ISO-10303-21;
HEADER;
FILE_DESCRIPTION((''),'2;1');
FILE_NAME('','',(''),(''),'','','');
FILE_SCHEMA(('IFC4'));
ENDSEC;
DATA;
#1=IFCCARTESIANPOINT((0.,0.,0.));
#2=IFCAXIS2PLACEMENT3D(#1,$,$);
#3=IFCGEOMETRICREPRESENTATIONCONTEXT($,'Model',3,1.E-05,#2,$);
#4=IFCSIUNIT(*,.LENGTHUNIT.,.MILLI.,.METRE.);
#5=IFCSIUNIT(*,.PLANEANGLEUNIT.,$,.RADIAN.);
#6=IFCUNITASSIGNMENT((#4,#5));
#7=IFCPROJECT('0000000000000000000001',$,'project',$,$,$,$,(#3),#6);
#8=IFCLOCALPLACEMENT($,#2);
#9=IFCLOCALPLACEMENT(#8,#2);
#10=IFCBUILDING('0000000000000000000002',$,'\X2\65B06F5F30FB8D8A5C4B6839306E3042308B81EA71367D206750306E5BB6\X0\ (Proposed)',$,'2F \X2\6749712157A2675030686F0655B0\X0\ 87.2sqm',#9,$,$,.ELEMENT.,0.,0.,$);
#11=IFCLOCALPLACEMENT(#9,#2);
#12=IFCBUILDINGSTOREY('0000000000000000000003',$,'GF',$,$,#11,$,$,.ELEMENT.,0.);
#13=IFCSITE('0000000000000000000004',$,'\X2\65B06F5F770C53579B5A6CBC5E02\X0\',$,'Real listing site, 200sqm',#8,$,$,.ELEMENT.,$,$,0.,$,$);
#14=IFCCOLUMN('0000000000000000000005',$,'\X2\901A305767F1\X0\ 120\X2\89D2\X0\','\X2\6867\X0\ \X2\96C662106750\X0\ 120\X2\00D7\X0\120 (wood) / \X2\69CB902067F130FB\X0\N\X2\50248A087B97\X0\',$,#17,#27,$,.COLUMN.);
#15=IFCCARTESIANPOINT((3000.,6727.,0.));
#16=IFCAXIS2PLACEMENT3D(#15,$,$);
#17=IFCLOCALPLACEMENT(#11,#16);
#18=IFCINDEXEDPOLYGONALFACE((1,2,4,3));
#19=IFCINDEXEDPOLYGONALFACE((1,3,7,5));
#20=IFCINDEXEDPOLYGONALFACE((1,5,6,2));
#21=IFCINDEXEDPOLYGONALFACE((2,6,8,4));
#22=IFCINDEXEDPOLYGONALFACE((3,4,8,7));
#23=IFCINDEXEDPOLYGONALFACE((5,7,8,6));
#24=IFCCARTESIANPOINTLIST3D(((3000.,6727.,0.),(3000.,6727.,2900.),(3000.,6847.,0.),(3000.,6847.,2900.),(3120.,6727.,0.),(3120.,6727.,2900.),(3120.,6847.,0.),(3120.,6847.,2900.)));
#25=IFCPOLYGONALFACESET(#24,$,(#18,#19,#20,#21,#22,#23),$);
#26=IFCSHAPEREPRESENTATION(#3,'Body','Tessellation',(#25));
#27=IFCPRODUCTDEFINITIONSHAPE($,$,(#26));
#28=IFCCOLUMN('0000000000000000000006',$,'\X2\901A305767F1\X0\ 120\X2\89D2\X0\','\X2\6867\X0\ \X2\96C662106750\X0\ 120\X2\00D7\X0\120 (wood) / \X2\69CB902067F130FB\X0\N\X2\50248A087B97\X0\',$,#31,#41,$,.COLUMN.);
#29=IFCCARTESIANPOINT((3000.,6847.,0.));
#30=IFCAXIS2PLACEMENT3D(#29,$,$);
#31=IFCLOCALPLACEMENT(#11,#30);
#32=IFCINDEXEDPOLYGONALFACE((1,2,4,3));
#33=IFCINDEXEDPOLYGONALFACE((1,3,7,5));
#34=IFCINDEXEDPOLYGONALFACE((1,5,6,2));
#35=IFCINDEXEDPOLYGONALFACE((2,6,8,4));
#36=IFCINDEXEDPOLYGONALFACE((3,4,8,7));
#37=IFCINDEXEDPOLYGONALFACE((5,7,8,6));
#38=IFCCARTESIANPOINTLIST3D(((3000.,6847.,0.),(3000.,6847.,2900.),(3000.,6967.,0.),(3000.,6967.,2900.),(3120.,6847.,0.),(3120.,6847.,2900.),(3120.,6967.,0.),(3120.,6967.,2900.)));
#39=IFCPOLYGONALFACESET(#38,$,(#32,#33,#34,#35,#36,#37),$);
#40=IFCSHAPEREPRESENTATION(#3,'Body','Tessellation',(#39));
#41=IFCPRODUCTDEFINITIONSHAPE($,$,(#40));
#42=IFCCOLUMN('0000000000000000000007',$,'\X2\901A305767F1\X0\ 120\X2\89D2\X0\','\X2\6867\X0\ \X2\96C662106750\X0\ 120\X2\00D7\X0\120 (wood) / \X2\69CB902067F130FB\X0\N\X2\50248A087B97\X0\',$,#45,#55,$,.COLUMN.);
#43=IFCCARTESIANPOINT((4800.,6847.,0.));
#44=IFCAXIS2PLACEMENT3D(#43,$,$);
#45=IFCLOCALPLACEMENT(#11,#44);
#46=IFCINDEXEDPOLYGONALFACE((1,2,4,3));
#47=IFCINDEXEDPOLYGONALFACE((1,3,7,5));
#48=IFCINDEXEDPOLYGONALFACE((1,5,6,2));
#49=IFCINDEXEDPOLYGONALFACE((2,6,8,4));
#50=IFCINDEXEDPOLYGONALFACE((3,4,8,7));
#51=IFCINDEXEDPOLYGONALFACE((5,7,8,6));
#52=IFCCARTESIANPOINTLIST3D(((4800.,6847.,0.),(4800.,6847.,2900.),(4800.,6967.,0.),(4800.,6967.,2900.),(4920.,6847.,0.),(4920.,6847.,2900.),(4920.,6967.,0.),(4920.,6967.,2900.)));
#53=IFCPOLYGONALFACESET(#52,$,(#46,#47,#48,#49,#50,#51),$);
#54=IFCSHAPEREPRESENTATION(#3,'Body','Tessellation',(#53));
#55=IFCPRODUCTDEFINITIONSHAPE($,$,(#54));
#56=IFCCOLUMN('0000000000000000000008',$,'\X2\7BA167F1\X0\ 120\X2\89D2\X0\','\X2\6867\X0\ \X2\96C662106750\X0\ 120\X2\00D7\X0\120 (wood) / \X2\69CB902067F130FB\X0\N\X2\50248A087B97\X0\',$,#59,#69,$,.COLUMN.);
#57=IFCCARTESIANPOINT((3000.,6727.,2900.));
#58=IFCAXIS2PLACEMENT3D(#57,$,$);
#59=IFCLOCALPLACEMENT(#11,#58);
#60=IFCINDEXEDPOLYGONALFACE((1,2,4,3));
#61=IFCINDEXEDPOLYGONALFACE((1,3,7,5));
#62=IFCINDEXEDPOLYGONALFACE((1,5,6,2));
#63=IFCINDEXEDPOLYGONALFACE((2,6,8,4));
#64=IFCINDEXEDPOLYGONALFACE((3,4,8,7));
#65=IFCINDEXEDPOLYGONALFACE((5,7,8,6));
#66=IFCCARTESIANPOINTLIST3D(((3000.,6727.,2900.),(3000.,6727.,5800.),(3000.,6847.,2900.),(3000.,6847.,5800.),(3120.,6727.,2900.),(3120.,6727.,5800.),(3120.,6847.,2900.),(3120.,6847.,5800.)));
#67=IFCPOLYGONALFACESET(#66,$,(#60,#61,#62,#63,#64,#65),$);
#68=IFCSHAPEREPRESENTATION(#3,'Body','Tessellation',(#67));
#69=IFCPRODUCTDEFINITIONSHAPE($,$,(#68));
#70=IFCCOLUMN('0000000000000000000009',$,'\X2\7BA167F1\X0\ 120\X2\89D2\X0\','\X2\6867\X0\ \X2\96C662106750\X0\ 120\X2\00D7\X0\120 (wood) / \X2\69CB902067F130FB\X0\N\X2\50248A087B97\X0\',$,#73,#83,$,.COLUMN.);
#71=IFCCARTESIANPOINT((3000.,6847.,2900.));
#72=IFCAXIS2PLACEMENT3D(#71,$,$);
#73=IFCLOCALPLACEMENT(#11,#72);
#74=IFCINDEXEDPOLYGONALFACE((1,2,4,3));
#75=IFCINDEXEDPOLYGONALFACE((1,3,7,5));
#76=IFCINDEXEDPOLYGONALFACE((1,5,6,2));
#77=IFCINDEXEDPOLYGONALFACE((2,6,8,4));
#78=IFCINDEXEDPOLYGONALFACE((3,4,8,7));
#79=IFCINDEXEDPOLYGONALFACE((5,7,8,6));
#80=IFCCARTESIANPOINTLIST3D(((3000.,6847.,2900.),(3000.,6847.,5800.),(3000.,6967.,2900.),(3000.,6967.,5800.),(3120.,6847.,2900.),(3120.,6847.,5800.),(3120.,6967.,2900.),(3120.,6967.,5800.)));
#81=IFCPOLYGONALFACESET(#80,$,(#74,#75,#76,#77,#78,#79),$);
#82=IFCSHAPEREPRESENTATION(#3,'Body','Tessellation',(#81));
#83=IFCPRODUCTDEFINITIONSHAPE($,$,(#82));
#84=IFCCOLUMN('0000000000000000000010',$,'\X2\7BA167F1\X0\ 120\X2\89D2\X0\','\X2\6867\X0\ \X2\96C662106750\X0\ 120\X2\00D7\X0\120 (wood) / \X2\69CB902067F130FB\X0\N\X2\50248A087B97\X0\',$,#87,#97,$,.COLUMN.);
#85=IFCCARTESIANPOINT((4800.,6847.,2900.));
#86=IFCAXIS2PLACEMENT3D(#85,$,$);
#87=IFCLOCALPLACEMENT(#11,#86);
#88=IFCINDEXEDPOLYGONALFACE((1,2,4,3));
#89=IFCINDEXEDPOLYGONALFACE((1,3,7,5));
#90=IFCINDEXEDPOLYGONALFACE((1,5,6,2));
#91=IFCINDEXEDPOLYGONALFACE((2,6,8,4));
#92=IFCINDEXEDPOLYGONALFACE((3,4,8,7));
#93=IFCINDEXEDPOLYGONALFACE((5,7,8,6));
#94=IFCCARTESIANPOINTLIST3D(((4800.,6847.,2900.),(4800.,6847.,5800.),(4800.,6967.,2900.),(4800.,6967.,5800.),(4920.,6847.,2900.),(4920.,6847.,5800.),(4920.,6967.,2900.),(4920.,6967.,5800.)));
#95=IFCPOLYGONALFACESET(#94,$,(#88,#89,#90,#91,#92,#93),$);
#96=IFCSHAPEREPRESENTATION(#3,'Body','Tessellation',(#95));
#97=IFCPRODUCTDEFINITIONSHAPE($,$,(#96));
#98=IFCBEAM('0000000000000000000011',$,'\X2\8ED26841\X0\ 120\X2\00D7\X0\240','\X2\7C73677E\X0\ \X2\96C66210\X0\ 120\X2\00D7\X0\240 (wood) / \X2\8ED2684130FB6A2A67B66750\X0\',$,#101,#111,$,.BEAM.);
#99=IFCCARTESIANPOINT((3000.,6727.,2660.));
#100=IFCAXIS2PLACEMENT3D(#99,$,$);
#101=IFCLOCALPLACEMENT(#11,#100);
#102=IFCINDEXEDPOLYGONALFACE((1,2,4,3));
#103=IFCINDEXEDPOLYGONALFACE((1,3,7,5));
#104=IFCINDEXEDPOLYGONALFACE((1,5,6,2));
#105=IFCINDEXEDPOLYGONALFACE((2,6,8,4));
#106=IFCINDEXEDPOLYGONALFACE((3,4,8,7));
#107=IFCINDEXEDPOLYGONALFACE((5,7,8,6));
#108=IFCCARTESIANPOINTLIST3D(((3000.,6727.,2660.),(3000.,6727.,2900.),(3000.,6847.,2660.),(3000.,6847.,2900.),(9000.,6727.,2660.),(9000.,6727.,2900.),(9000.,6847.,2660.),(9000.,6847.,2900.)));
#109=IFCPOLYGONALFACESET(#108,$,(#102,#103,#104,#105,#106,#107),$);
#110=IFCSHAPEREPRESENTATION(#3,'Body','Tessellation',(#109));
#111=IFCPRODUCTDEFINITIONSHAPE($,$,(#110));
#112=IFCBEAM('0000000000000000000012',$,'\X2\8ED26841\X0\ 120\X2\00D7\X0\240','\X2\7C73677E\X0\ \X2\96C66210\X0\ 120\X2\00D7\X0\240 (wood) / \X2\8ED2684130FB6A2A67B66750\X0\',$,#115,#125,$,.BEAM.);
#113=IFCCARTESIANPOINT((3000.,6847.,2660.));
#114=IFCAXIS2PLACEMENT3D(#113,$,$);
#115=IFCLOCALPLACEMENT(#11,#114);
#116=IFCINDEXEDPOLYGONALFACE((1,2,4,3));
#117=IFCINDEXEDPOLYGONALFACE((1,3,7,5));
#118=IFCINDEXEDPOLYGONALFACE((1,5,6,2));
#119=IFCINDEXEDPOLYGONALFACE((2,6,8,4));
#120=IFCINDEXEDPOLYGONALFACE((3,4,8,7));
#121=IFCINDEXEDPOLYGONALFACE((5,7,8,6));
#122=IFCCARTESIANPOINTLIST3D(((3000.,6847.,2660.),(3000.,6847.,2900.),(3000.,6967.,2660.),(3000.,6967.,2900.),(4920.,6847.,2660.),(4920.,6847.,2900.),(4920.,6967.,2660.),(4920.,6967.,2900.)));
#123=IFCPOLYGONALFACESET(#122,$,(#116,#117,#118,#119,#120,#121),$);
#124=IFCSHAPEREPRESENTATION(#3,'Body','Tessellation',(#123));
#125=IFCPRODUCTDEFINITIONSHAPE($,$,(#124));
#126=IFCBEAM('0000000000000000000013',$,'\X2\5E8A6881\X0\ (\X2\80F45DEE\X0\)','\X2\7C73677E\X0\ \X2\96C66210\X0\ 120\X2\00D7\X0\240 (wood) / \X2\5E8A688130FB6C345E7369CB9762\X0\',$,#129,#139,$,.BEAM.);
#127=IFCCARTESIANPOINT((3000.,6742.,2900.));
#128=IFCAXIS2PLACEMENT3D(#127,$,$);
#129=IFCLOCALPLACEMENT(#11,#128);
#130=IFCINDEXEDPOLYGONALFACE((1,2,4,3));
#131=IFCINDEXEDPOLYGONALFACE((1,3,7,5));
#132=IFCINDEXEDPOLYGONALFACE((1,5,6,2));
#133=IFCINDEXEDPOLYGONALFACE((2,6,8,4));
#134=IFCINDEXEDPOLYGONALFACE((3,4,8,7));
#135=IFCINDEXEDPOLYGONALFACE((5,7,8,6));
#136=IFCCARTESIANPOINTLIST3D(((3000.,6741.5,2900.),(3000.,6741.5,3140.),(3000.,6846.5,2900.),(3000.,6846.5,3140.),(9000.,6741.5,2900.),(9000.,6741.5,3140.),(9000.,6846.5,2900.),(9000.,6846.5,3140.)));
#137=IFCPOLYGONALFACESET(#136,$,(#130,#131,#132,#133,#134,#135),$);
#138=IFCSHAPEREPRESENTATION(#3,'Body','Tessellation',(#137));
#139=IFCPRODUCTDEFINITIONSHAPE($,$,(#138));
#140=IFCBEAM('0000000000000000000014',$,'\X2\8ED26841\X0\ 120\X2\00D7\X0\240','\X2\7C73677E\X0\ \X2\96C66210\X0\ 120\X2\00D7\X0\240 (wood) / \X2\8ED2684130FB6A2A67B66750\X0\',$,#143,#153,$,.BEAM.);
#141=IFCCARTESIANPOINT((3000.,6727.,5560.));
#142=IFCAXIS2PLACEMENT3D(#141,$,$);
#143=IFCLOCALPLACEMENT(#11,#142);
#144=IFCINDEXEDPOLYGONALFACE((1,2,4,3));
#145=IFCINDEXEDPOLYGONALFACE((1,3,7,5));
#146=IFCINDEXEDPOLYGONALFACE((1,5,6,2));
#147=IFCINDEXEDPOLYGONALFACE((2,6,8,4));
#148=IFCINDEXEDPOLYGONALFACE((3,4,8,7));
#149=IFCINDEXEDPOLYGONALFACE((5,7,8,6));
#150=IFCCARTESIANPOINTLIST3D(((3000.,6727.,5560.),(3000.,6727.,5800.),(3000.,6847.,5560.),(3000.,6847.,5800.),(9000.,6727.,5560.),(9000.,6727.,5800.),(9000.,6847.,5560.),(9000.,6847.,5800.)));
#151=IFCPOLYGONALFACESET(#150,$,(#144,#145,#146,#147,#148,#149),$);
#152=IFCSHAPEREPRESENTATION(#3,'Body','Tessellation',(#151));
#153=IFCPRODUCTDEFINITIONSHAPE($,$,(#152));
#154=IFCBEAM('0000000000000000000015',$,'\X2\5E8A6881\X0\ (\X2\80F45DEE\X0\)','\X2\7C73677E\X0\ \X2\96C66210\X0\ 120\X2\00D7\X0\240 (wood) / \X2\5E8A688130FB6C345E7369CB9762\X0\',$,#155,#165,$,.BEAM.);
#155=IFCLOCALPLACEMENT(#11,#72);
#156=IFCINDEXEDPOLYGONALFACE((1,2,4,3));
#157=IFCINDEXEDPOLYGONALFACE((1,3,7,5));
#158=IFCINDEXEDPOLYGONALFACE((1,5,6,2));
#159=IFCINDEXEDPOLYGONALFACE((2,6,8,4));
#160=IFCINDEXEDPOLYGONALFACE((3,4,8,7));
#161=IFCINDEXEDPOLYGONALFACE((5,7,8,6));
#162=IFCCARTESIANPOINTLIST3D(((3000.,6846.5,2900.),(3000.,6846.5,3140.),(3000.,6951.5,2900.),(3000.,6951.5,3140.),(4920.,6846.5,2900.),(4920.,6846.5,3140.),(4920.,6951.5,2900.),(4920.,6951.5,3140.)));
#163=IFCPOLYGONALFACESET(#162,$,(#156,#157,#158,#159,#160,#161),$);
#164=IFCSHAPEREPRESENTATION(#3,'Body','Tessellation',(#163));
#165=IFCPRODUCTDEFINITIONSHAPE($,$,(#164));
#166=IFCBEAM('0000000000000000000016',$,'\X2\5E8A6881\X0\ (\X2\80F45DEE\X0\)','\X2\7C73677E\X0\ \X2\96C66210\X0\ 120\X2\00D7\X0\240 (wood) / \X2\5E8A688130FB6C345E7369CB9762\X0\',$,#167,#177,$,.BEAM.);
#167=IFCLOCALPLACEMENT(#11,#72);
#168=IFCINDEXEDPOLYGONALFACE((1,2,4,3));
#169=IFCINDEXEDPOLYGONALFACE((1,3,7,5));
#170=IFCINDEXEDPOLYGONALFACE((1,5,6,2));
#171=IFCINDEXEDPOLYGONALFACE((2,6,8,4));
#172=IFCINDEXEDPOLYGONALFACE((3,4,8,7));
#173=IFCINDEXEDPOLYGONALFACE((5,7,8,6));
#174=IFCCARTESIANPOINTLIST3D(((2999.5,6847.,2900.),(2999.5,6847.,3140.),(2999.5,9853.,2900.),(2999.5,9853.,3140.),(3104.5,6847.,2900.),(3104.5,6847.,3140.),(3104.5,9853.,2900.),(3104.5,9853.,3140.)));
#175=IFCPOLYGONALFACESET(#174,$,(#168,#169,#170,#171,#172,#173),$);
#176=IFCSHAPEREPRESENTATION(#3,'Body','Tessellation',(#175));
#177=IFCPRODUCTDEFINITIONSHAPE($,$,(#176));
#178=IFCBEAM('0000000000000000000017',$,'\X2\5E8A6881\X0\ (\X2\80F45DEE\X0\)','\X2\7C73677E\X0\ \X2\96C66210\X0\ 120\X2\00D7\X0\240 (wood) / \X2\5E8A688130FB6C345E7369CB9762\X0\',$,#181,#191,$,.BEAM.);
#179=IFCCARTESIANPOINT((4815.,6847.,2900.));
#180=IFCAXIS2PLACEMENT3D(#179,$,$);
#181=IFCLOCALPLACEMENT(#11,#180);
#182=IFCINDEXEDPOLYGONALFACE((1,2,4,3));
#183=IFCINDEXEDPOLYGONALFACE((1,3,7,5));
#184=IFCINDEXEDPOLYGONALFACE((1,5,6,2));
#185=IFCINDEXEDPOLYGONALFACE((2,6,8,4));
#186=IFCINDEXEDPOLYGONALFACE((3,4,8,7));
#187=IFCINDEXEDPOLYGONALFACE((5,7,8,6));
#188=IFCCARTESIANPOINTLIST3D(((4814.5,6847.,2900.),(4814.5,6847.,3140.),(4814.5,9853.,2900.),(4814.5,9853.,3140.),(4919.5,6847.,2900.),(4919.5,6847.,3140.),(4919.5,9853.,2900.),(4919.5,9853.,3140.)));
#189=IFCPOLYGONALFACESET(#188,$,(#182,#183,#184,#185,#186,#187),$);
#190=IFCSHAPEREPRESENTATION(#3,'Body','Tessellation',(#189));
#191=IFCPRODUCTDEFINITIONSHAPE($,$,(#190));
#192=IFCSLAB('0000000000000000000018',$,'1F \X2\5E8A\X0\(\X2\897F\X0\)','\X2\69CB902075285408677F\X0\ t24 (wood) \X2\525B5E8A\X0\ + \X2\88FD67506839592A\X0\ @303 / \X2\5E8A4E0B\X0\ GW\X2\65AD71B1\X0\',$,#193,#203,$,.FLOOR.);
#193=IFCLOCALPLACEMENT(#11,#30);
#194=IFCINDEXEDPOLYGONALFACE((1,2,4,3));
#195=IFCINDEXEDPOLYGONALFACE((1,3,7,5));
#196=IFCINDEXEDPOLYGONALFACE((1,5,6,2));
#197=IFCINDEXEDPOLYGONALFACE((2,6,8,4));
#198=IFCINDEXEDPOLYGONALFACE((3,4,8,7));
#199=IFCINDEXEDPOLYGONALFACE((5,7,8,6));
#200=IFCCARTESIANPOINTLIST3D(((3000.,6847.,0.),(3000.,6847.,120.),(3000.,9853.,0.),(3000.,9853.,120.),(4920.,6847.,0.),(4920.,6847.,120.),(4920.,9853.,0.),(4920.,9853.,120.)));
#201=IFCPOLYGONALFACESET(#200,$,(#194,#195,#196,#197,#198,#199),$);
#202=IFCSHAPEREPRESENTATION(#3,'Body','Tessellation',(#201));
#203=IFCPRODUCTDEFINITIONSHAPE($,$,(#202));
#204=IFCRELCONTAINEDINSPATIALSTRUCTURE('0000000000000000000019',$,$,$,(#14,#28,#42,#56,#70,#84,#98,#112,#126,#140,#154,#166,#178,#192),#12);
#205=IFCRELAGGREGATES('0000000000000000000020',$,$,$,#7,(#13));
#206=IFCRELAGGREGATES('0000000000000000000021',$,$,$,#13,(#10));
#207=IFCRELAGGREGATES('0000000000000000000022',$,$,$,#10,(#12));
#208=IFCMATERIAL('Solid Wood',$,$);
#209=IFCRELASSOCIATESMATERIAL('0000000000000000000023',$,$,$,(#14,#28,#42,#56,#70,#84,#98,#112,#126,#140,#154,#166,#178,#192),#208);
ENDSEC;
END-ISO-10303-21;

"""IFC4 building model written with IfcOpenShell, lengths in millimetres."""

from ifc_helpers import new_model, si_unit, frame, frame_2d, origin, place, context, project, spatial, rectangle, extrude, material, element, save


model = new_model("IFC4")

# Units and contexts
model_context = context("Model", 3, precision=1e-05, world=origin())
ifc_project = project(units=[si_unit("LENGTHUNIT", "METRE", prefix="MILLI"), si_unit("PLANEANGLEUNIT", "RADIAN")], contexts=[model_context])

# Site, building, storey
site_placement = place(None, origin())
site = spatial("IfcSite", under=ifc_project, at=site_placement, Name="新潟県南魚沼市", ObjectType="Real listing site, 200sqm", CompositionType="ELEMENT", RefElevation=0.0)
building_placement = place(site_placement, origin())
building = spatial("IfcBuilding", under=site, at=building_placement, Name="新潟・越屋根のある自然素材の家 (Proposed)", ObjectType="2F 杉無垢材と漆喰 87.2sqm", CompositionType="ELEMENT", ElevationOfRefHeight=0.0, ElevationOfTerrain=0.0)
storey_placement = place(building_placement, origin())
storey = spatial("IfcBuildingStorey", under=building, at=storey_placement, Name="GF", CompositionType="ELEMENT", Elevation=0.0)

# Columns
ifc_material_1 = material(Name="Solid Wood")
column_1_placement = place(storey_placement, frame((3000.0, 6727.0, 0.0)))
element("IfcColumn", 1, at=column_1_placement, inside=storey, material=ifc_material_1, Name="通し柱 120角", Description="桧 集成材 120×120 (wood) / 構造柱・N値計算", PredefinedType="COLUMN", context=model_context, shape_type="SweptSolid", body=[
    extrude(rectangle(XDim=120.0, YDim=120.0, at=frame_2d((60.0, 60.0))), frame((3000.0, 6727.0, 0.0)), (0.0, 0.0, 1.0), 2900.0),
])
column_2_placement = place(storey_placement, frame((3000.0, 6847.0, 0.0)))
element("IfcColumn", 2, at=column_2_placement, inside=storey, material=ifc_material_1, Name="通し柱 120角", Description="桧 集成材 120×120 (wood) / 構造柱・N値計算", PredefinedType="COLUMN", context=model_context, shape_type="SweptSolid", body=[
    extrude(rectangle(XDim=120.0, YDim=120.0, at=frame_2d((60.0, 60.0))), frame((3000.0, 6847.0, 0.0)), (0.0, 0.0, 1.0), 2900.0),
])
column_3_placement = place(storey_placement, frame((4800.0, 6847.0, 0.0)))
element("IfcColumn", 3, at=column_3_placement, inside=storey, material=ifc_material_1, Name="通し柱 120角", Description="桧 集成材 120×120 (wood) / 構造柱・N値計算", PredefinedType="COLUMN", context=model_context, shape_type="SweptSolid", body=[
    extrude(rectangle(XDim=120.0, YDim=120.0, at=frame_2d((60.0, 60.0))), frame((4800.0, 6847.0, 0.0)), (0.0, 0.0, 1.0), 2900.0),
])
column_4_placement = place(storey_placement, frame((3000.0, 6727.0, 2900.0)))
element("IfcColumn", 4, at=column_4_placement, inside=storey, material=ifc_material_1, Name="管柱 120角", Description="桧 集成材 120×120 (wood) / 構造柱・N値計算", PredefinedType="COLUMN", context=model_context, shape_type="SweptSolid", body=[
    extrude(rectangle(XDim=120.0, YDim=120.0, at=frame_2d((60.0, 60.0))), frame((3000.0, 6727.0, 2900.0)), (0.0, 0.0, 1.0), 2900.0),
])
column_5_placement = place(storey_placement, frame((3000.0, 6847.0, 2900.0)))
element("IfcColumn", 5, at=column_5_placement, inside=storey, material=ifc_material_1, Name="管柱 120角", Description="桧 集成材 120×120 (wood) / 構造柱・N値計算", PredefinedType="COLUMN", context=model_context, shape_type="SweptSolid", body=[
    extrude(rectangle(XDim=120.0, YDim=120.0, at=frame_2d((60.0, 60.0))), frame((3000.0, 6847.0, 2900.0)), (0.0, 0.0, 1.0), 2900.0),
])
column_6_placement = place(storey_placement, frame((4800.0, 6847.0, 2900.0)))
element("IfcColumn", 6, at=column_6_placement, inside=storey, material=ifc_material_1, Name="管柱 120角", Description="桧 集成材 120×120 (wood) / 構造柱・N値計算", PredefinedType="COLUMN", context=model_context, shape_type="SweptSolid", body=[
    extrude(rectangle(XDim=120.0, YDim=120.0, at=frame_2d((60.0, 60.0))), frame((4800.0, 6847.0, 2900.0)), (0.0, 0.0, 1.0), 2900.0),
])

# Beams
beam_1_placement = place(storey_placement, frame((3000.0, 6727.0, 2660.0)))
element("IfcBeam", 7, at=beam_1_placement, inside=storey, material=ifc_material_1, Name="軒桁 120×240", Description="米松 集成 120×240 (wood) / 軒桁・横架材", PredefinedType="BEAM", context=model_context, shape_type="SweptSolid", body=[
    extrude(rectangle(XDim=6000.0, YDim=120.0, at=frame_2d((3000.0, 60.0))), frame((3000.0, 6727.0, 2660.0)), (0.0, 0.0, 1.0), 240.0),
])
beam_2_placement = place(storey_placement, frame((3000.0, 6847.0, 2660.0)))
element("IfcBeam", 8, at=beam_2_placement, inside=storey, material=ifc_material_1, Name="軒桁 120×240", Description="米松 集成 120×240 (wood) / 軒桁・横架材", PredefinedType="BEAM", context=model_context, shape_type="SweptSolid", body=[
    extrude(rectangle(XDim=1920.0, YDim=120.0, at=frame_2d((960.0, 60.0))), frame((3000.0, 6847.0, 2660.0)), (0.0, 0.0, 1.0), 240.0),
])
beam_3_placement = place(storey_placement, frame((3000.0, 6742.0, 2900.0)))
element("IfcBeam", 9, at=beam_3_placement, inside=storey, material=ifc_material_1, Name="床梁 (胴差)", Description="米松 集成 120×240 (wood) / 床梁・水平構面", PredefinedType="BEAM", context=model_context, shape_type="SweptSolid", body=[
    extrude(rectangle(XDim=6000.0, YDim=105.0, at=frame_2d((3000.0, 52.0))), frame((3000.0, 6742.0, 2900.0)), (0.0, 0.0, 1.0), 240.0),
])
beam_4_placement = place(storey_placement, frame((3000.0, 6727.0, 5560.0)))
element("IfcBeam", 10, at=beam_4_placement, inside=storey, material=ifc_material_1, Name="軒桁 120×240", Description="米松 集成 120×240 (wood) / 軒桁・横架材", PredefinedType="BEAM", context=model_context, shape_type="SweptSolid", body=[
    extrude(rectangle(XDim=6000.0, YDim=120.0, at=frame_2d((3000.0, 60.0))), frame((3000.0, 6727.0, 5560.0)), (0.0, 0.0, 1.0), 240.0),
])
beam_5_placement = place(storey_placement, frame((3000.0, 6847.0, 2900.0)))
element("IfcBeam", 11, at=beam_5_placement, inside=storey, material=ifc_material_1, Name="床梁 (胴差)", Description="米松 集成 120×240 (wood) / 床梁・水平構面", PredefinedType="BEAM", context=model_context, shape_type="SweptSolid", body=[
    extrude(rectangle(XDim=1920.0, YDim=105.0, at=frame_2d((960.0, 52.0))), frame((3000.0, 6847.0, 2900.0)), (0.0, 0.0, 1.0), 240.0),
])
beam_6_placement = place(storey_placement, frame((3000.0, 6847.0, 2900.0)))
element("IfcBeam", 12, at=beam_6_placement, inside=storey, material=ifc_material_1, Name="床梁 (胴差)", Description="米松 集成 120×240 (wood) / 床梁・水平構面", PredefinedType="BEAM", context=model_context, shape_type="SweptSolid", body=[
    extrude(rectangle(XDim=105.0, YDim=3006.0, at=frame_2d((52.0, 1503.0))), frame((3000.0, 6847.0, 2900.0)), (0.0, 0.0, 1.0), 240.0),
])
beam_7_placement = place(storey_placement, frame((4815.0, 6847.0, 2900.0)))
element("IfcBeam", 13, at=beam_7_placement, inside=storey, material=ifc_material_1, Name="床梁 (胴差)", Description="米松 集成 120×240 (wood) / 床梁・水平構面", PredefinedType="BEAM", context=model_context, shape_type="SweptSolid", body=[
    extrude(rectangle(XDim=105.0, YDim=3006.0, at=frame_2d((52.0, 1503.0))), frame((4815.0, 6847.0, 2900.0)), (0.0, 0.0, 1.0), 240.0),
])

# Slab
slab_1_placement = place(storey_placement, frame((3000.0, 6847.0, 0.0)))
element("IfcSlab", 14, at=slab_1_placement, inside=storey, material=ifc_material_1, Name="1F 床(西)", Description="構造用合板 t24 (wood) 剛床 + 製材根太 @303 / 床下 GW断熱", PredefinedType="FLOOR", context=model_context, shape_type="SweptSolid", body=[
    extrude(rectangle(XDim=1920.0, YDim=3006.0, at=frame_2d((960.0, 1503.0))), frame((3000.0, 6847.0, 0.0)), (0.0, 0.0, 1.0), 120.0),
])

save(model, "model.ifc")
